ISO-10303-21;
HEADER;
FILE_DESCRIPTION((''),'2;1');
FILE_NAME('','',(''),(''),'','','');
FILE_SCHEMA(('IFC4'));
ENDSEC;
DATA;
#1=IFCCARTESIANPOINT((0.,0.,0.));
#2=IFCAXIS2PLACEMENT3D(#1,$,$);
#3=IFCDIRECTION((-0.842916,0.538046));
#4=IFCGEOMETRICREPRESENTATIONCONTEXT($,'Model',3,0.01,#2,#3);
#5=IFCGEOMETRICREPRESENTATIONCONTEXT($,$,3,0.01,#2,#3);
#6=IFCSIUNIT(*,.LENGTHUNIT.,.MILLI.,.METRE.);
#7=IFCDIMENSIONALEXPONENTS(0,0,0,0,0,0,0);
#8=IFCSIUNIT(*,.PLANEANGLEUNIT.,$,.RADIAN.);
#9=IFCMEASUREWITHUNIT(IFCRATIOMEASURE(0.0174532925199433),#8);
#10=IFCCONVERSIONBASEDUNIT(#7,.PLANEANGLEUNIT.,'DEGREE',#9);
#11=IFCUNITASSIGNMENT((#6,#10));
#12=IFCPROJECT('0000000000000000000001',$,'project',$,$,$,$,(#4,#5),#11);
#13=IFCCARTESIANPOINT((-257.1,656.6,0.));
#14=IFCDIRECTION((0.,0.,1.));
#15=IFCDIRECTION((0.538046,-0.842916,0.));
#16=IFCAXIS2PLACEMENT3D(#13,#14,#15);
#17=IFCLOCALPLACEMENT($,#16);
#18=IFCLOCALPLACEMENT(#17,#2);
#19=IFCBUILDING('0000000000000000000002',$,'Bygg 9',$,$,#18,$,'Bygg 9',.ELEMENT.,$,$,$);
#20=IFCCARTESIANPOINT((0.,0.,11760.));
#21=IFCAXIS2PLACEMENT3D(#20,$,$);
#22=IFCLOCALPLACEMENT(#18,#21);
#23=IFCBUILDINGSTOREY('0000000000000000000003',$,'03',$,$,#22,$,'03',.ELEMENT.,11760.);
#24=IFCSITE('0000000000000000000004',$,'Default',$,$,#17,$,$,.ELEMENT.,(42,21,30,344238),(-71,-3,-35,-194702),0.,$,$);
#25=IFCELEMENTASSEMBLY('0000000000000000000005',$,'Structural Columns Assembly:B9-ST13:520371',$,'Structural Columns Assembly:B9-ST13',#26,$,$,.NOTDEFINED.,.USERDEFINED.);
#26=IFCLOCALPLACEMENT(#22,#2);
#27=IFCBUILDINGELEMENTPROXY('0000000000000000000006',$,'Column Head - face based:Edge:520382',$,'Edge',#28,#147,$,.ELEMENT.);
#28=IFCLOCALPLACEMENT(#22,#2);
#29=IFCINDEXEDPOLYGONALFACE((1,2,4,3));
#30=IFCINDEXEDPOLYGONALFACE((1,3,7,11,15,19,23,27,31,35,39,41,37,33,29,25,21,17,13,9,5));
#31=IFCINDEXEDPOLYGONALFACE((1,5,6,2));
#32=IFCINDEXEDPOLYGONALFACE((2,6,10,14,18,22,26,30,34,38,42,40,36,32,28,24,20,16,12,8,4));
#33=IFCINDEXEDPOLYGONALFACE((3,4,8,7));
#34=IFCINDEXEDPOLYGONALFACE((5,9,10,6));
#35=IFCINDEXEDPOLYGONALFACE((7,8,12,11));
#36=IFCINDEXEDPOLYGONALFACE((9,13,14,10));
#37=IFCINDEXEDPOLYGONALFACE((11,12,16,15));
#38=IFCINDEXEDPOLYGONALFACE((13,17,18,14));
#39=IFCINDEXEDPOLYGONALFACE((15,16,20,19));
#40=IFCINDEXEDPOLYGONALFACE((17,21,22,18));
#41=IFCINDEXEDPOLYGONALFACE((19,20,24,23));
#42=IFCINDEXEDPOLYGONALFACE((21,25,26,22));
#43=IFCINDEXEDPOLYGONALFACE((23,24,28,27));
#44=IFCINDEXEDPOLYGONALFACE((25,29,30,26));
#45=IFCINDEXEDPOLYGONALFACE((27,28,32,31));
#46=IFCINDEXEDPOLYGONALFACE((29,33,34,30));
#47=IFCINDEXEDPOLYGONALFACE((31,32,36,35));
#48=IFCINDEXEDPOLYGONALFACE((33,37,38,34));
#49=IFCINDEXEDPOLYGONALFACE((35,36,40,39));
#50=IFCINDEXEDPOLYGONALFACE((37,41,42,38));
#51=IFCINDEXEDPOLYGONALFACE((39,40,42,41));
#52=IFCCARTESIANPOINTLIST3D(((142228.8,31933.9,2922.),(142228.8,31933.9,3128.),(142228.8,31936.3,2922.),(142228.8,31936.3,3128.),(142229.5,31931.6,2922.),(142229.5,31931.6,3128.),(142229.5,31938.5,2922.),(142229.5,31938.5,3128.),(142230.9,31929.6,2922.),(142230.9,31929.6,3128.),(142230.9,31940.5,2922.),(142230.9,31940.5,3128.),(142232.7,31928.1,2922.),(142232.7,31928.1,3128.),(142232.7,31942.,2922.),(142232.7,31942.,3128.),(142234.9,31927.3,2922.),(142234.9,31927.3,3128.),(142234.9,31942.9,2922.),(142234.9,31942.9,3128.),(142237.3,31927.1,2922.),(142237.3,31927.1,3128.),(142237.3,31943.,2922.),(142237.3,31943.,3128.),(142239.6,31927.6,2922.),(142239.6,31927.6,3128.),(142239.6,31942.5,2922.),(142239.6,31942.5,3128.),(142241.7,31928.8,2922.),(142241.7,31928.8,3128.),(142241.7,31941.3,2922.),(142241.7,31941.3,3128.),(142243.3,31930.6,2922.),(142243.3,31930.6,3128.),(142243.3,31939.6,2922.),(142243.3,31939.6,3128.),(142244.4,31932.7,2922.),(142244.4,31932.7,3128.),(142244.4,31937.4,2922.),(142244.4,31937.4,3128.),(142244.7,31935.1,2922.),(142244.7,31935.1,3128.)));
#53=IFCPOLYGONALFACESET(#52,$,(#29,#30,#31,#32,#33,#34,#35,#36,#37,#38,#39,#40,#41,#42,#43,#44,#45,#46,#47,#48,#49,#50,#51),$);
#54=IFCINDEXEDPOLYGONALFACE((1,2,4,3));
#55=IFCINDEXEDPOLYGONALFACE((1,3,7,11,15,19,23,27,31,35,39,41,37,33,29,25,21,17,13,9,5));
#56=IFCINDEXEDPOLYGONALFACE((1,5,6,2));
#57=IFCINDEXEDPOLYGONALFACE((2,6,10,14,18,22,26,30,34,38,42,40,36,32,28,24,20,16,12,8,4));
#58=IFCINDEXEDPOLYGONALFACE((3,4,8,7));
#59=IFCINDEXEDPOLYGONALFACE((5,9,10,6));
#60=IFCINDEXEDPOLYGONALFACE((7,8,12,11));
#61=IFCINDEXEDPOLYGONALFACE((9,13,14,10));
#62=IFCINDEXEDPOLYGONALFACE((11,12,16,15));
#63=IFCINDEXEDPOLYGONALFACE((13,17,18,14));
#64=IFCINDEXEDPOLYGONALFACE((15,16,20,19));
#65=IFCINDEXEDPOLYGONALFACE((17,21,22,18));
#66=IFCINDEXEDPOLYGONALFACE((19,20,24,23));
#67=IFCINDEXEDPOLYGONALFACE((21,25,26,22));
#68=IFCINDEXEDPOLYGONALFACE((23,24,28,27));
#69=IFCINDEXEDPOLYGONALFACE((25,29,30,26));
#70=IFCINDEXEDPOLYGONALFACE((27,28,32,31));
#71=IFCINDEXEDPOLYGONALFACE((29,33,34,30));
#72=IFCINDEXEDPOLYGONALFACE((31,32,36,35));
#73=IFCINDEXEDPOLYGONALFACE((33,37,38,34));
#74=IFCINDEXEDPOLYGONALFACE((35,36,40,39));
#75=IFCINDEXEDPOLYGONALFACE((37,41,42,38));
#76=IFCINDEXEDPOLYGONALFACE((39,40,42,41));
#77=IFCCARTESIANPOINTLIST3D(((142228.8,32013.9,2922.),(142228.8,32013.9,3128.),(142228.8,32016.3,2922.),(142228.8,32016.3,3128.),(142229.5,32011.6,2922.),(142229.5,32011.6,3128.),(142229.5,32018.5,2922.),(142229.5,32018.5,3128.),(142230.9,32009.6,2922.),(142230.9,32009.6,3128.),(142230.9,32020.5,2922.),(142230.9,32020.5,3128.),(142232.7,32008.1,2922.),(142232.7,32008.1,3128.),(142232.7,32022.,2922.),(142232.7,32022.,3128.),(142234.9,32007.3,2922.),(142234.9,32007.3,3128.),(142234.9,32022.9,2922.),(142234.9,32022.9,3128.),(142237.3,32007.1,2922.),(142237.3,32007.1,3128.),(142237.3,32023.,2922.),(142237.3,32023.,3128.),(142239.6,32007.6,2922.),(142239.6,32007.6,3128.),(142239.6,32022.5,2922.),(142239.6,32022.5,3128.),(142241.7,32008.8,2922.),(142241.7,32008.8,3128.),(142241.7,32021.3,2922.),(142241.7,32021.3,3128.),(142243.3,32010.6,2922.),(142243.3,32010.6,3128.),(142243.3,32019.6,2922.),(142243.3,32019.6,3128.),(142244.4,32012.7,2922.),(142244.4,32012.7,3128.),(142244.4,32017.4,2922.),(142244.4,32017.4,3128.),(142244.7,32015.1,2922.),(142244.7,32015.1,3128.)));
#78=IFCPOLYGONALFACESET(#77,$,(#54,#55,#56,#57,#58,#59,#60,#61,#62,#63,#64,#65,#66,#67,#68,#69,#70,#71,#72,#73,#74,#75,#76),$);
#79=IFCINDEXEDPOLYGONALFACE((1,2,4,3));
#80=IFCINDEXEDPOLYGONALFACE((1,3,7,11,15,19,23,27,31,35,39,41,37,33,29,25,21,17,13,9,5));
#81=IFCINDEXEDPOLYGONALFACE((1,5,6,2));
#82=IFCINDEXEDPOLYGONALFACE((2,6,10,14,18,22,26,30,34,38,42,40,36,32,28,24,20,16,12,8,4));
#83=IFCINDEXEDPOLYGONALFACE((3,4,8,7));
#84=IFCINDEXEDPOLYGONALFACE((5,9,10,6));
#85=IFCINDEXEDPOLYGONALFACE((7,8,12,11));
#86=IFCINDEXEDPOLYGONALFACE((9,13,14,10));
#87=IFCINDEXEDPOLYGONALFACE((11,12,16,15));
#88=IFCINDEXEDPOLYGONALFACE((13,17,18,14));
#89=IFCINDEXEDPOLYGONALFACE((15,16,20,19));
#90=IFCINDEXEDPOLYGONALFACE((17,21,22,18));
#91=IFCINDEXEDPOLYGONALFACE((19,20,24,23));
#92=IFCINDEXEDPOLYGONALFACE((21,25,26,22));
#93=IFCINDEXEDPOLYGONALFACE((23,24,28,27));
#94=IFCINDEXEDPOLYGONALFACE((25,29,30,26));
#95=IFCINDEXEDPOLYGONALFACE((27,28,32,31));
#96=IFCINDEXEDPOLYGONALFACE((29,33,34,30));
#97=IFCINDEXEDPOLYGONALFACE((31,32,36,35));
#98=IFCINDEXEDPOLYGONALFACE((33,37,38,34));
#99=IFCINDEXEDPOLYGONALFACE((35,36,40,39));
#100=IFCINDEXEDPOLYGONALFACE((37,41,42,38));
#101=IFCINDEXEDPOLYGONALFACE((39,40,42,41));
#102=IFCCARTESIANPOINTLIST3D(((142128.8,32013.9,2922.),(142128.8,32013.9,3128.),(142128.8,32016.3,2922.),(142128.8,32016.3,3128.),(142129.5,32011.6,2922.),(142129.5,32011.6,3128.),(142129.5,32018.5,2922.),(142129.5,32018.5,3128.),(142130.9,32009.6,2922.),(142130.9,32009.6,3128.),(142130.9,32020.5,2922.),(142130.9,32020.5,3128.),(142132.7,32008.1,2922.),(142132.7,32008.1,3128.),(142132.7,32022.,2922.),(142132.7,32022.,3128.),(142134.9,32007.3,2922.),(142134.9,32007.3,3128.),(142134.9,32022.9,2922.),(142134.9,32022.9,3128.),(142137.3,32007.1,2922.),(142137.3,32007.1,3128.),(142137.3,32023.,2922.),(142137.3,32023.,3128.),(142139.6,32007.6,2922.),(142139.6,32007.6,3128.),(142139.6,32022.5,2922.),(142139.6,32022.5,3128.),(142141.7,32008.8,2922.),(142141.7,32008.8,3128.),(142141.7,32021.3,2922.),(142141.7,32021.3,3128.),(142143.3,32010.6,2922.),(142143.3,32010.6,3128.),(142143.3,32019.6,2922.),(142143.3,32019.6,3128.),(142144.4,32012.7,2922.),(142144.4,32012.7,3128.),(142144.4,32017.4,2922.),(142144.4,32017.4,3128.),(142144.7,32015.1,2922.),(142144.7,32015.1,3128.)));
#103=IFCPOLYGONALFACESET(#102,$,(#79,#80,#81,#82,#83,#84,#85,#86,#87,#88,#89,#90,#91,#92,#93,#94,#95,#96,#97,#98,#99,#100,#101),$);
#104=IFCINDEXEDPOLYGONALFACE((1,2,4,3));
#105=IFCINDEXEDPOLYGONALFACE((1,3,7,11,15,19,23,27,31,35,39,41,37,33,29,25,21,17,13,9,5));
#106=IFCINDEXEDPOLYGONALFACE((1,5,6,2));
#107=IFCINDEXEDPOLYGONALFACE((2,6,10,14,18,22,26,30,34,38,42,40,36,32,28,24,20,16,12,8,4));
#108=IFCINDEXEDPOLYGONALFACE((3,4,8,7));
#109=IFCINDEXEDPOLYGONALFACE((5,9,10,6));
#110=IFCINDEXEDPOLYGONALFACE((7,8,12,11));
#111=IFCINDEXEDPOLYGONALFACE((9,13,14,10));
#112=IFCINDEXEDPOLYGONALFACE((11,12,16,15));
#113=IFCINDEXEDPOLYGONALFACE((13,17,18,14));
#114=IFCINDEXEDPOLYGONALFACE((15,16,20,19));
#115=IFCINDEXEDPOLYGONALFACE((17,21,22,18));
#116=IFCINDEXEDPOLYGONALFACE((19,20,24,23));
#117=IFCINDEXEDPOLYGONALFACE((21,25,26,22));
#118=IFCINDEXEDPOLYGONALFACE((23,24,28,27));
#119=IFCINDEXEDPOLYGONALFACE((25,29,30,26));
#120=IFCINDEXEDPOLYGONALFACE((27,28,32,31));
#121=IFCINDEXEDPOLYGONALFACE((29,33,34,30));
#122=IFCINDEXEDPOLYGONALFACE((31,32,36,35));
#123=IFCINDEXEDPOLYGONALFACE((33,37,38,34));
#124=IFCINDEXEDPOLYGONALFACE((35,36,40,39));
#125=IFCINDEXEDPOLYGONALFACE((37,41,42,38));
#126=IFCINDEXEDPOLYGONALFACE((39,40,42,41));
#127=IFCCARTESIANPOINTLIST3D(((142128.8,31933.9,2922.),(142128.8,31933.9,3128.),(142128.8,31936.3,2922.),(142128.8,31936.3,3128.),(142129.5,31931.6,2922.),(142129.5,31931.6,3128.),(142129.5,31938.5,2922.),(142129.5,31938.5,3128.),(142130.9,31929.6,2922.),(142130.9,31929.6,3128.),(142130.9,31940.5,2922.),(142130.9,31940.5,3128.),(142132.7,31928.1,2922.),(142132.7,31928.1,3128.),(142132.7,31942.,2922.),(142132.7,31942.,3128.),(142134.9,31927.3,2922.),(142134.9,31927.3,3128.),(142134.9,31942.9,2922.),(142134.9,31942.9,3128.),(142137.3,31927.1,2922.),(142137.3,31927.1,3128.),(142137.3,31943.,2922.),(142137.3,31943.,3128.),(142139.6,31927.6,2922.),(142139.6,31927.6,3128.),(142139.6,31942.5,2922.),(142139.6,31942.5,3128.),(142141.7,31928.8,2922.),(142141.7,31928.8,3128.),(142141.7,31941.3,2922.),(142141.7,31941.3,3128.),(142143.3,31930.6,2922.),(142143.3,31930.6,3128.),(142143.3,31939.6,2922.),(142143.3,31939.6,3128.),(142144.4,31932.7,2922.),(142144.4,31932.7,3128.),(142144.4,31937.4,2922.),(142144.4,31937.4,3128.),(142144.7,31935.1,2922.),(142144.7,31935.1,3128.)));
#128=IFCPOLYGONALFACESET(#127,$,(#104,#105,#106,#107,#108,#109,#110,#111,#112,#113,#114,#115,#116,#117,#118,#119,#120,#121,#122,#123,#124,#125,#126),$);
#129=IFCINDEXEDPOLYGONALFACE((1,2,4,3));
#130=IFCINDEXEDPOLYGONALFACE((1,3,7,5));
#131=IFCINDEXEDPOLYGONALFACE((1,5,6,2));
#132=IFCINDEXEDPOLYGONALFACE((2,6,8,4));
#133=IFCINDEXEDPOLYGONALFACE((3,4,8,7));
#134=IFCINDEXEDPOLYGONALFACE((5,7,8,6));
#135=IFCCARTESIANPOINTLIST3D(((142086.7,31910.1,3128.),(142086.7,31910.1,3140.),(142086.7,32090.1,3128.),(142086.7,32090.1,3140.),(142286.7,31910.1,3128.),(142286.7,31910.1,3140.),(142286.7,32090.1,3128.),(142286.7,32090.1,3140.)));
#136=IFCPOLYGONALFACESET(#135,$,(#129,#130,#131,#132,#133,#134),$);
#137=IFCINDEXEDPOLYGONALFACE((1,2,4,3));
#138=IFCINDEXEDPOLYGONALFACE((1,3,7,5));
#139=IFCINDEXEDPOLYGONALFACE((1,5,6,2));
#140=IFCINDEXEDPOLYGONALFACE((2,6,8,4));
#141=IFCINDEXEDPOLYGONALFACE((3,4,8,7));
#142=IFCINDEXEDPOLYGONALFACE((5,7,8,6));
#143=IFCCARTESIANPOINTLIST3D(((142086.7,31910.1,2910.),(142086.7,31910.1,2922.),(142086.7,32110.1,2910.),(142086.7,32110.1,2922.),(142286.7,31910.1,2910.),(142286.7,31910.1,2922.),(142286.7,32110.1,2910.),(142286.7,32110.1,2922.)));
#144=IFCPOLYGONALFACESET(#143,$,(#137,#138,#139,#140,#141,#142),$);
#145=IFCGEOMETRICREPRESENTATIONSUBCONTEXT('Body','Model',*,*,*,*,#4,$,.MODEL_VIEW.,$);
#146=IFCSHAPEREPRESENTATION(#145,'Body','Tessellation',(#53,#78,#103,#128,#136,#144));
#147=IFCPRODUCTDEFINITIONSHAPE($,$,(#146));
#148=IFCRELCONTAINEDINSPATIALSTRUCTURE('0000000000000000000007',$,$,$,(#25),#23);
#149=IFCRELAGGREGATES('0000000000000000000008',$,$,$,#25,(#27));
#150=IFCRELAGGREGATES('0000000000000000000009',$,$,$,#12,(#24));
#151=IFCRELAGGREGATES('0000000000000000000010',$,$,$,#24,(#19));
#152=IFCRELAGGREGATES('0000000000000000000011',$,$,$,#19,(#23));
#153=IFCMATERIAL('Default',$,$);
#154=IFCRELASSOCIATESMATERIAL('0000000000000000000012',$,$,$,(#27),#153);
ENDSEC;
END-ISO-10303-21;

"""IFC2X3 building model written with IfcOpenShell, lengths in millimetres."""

from ifc_helpers import new_model, entity, si_unit, converted_unit, direction, frame, frame_2d, origin, origin_2d_with_axis, place, context, subcontext, project, spatial, rectangle, circle, extrude, source, transform, mapped, material, element, aggregate, save


model = new_model("IFC2X3")

# Units and contexts
model_context = context("Model", 3, precision=0.01, world=origin(), true_north=direction((-0.842916, 0.538046)))
context_of_model = context(None, 3, precision=0.01, world=origin(), true_north=direction((-0.842916, 0.538046)))
body_context = subcontext(model_context, "Body", "Model", "MODEL_VIEW")
ifc_project = project(units=[si_unit("LENGTHUNIT", "METRE", prefix="MILLI"), converted_unit("PLANEANGLEUNIT", "DEGREE", entity("IfcRatioMeasure", 0.0174532925199433), si_unit("PLANEANGLEUNIT", "RADIAN"), dimensions=[0, 0, 0, 0, 0, 0, 0])], contexts=[model_context, context_of_model])

# Site, building, storey
site_placement = place(None, frame((-257.1, 656.6, 0.0), z_axis=(0.0, 0.0, 1.0), x_axis=(0.538046, -0.842916, 0.0)))
site = spatial("IfcSite", under=ifc_project, at=site_placement, Name="Default", CompositionType="ELEMENT", RefLatitude=(42, 21, 30, 344238), RefLongitude=(-71, -3, -35, -194702), RefElevation=0.0)
building_placement = place(site_placement, origin())
building = spatial("IfcBuilding", under=site, at=building_placement, Name="Bygg 9", LongName="Bygg 9", CompositionType="ELEMENT")
storey_placement = place(building_placement, frame((0.0, 0.0, 11760.0)))
storey = spatial("IfcBuildingStorey", under=building, at=storey_placement, Name="03", LongName="03", CompositionType="ELEMENT", Elevation=11760.0)

# Shared definitions
ifc_material_1 = material(Name="Default")

# Element assembly, building element proxy
shared_shape_1 = source(origin(), body_context, "Body", "SweptSolid", [
    extrude(circle(Radius=8.0, at=frame_2d((0.0, 0.0), x_axis=(1.0, 0.0))), frame((50.0, -135.0, 12.0)), (0.0, 0.0, 1.0), 206.0),
    extrude(circle(Radius=8.0, at=frame_2d((0.0, 0.0), x_axis=(1.0, 0.0))), frame((50.0, -55.0, 12.0)), (0.0, 0.0, 1.0), 206.0),
    extrude(circle(Radius=8.0, at=frame_2d((0.0, 0.0), x_axis=(1.0, 0.0))), frame((-50.0, -55.0, 12.0)), (0.0, 0.0, 1.0), 206.0),
    extrude(circle(Radius=8.0, at=frame_2d((0.0, 0.0), x_axis=(1.0, 0.0))), frame((-50.0, -135.0, 12.0)), (0.0, 0.0, 1.0), 206.0),
    extrude(rectangle(XDim=200.0, YDim=180.0, at=origin_2d_with_axis()), frame((0.0, -70.0, 218.0), z_axis=(0.0, 0.0, 1.0), x_axis=(-1.0, 0.0, 0.0)), (0.0, 0.0, 1.0), 12.0),
    extrude(rectangle(XDim=200.0, YDim=200.0, at=origin_2d_with_axis()), frame((0.0, -60.0, 0.0), z_axis=(0.0, 0.0, 1.0), x_axis=(0.0, 1.0, 0.0)), (0.0, 0.0, 1.0), 12.0),
])
assembly_1_placement = place(storey_placement, origin())
assembly_1 = element("IfcElementAssembly", 1, at=assembly_1_placement, inside=storey, Name="Structural Columns Assembly:B9-ST13:520371", ObjectType="Structural Columns Assembly:B9-ST13", AssemblyPlace="NOTDEFINED", PredefinedType="USERDEFINED")
proxy_1_placement = place(assembly_1_placement, frame((142186.7, 32070.1, 2910.0)))
proxy_1 = element("IfcBuildingElementProxy", 2, at=proxy_1_placement, material=ifc_material_1, Name="Column Head - face based:Edge:520382", ObjectType="Edge", CompositionType="ELEMENT", context=body_context, shape_type="MappedRepresentation", body=[
    mapped(shared_shape_1, transform((0.0, 0.0, 0.0), scale=1.0)),
])
aggregate(assembly_1, [proxy_1])

save(model, "model.ifc")
